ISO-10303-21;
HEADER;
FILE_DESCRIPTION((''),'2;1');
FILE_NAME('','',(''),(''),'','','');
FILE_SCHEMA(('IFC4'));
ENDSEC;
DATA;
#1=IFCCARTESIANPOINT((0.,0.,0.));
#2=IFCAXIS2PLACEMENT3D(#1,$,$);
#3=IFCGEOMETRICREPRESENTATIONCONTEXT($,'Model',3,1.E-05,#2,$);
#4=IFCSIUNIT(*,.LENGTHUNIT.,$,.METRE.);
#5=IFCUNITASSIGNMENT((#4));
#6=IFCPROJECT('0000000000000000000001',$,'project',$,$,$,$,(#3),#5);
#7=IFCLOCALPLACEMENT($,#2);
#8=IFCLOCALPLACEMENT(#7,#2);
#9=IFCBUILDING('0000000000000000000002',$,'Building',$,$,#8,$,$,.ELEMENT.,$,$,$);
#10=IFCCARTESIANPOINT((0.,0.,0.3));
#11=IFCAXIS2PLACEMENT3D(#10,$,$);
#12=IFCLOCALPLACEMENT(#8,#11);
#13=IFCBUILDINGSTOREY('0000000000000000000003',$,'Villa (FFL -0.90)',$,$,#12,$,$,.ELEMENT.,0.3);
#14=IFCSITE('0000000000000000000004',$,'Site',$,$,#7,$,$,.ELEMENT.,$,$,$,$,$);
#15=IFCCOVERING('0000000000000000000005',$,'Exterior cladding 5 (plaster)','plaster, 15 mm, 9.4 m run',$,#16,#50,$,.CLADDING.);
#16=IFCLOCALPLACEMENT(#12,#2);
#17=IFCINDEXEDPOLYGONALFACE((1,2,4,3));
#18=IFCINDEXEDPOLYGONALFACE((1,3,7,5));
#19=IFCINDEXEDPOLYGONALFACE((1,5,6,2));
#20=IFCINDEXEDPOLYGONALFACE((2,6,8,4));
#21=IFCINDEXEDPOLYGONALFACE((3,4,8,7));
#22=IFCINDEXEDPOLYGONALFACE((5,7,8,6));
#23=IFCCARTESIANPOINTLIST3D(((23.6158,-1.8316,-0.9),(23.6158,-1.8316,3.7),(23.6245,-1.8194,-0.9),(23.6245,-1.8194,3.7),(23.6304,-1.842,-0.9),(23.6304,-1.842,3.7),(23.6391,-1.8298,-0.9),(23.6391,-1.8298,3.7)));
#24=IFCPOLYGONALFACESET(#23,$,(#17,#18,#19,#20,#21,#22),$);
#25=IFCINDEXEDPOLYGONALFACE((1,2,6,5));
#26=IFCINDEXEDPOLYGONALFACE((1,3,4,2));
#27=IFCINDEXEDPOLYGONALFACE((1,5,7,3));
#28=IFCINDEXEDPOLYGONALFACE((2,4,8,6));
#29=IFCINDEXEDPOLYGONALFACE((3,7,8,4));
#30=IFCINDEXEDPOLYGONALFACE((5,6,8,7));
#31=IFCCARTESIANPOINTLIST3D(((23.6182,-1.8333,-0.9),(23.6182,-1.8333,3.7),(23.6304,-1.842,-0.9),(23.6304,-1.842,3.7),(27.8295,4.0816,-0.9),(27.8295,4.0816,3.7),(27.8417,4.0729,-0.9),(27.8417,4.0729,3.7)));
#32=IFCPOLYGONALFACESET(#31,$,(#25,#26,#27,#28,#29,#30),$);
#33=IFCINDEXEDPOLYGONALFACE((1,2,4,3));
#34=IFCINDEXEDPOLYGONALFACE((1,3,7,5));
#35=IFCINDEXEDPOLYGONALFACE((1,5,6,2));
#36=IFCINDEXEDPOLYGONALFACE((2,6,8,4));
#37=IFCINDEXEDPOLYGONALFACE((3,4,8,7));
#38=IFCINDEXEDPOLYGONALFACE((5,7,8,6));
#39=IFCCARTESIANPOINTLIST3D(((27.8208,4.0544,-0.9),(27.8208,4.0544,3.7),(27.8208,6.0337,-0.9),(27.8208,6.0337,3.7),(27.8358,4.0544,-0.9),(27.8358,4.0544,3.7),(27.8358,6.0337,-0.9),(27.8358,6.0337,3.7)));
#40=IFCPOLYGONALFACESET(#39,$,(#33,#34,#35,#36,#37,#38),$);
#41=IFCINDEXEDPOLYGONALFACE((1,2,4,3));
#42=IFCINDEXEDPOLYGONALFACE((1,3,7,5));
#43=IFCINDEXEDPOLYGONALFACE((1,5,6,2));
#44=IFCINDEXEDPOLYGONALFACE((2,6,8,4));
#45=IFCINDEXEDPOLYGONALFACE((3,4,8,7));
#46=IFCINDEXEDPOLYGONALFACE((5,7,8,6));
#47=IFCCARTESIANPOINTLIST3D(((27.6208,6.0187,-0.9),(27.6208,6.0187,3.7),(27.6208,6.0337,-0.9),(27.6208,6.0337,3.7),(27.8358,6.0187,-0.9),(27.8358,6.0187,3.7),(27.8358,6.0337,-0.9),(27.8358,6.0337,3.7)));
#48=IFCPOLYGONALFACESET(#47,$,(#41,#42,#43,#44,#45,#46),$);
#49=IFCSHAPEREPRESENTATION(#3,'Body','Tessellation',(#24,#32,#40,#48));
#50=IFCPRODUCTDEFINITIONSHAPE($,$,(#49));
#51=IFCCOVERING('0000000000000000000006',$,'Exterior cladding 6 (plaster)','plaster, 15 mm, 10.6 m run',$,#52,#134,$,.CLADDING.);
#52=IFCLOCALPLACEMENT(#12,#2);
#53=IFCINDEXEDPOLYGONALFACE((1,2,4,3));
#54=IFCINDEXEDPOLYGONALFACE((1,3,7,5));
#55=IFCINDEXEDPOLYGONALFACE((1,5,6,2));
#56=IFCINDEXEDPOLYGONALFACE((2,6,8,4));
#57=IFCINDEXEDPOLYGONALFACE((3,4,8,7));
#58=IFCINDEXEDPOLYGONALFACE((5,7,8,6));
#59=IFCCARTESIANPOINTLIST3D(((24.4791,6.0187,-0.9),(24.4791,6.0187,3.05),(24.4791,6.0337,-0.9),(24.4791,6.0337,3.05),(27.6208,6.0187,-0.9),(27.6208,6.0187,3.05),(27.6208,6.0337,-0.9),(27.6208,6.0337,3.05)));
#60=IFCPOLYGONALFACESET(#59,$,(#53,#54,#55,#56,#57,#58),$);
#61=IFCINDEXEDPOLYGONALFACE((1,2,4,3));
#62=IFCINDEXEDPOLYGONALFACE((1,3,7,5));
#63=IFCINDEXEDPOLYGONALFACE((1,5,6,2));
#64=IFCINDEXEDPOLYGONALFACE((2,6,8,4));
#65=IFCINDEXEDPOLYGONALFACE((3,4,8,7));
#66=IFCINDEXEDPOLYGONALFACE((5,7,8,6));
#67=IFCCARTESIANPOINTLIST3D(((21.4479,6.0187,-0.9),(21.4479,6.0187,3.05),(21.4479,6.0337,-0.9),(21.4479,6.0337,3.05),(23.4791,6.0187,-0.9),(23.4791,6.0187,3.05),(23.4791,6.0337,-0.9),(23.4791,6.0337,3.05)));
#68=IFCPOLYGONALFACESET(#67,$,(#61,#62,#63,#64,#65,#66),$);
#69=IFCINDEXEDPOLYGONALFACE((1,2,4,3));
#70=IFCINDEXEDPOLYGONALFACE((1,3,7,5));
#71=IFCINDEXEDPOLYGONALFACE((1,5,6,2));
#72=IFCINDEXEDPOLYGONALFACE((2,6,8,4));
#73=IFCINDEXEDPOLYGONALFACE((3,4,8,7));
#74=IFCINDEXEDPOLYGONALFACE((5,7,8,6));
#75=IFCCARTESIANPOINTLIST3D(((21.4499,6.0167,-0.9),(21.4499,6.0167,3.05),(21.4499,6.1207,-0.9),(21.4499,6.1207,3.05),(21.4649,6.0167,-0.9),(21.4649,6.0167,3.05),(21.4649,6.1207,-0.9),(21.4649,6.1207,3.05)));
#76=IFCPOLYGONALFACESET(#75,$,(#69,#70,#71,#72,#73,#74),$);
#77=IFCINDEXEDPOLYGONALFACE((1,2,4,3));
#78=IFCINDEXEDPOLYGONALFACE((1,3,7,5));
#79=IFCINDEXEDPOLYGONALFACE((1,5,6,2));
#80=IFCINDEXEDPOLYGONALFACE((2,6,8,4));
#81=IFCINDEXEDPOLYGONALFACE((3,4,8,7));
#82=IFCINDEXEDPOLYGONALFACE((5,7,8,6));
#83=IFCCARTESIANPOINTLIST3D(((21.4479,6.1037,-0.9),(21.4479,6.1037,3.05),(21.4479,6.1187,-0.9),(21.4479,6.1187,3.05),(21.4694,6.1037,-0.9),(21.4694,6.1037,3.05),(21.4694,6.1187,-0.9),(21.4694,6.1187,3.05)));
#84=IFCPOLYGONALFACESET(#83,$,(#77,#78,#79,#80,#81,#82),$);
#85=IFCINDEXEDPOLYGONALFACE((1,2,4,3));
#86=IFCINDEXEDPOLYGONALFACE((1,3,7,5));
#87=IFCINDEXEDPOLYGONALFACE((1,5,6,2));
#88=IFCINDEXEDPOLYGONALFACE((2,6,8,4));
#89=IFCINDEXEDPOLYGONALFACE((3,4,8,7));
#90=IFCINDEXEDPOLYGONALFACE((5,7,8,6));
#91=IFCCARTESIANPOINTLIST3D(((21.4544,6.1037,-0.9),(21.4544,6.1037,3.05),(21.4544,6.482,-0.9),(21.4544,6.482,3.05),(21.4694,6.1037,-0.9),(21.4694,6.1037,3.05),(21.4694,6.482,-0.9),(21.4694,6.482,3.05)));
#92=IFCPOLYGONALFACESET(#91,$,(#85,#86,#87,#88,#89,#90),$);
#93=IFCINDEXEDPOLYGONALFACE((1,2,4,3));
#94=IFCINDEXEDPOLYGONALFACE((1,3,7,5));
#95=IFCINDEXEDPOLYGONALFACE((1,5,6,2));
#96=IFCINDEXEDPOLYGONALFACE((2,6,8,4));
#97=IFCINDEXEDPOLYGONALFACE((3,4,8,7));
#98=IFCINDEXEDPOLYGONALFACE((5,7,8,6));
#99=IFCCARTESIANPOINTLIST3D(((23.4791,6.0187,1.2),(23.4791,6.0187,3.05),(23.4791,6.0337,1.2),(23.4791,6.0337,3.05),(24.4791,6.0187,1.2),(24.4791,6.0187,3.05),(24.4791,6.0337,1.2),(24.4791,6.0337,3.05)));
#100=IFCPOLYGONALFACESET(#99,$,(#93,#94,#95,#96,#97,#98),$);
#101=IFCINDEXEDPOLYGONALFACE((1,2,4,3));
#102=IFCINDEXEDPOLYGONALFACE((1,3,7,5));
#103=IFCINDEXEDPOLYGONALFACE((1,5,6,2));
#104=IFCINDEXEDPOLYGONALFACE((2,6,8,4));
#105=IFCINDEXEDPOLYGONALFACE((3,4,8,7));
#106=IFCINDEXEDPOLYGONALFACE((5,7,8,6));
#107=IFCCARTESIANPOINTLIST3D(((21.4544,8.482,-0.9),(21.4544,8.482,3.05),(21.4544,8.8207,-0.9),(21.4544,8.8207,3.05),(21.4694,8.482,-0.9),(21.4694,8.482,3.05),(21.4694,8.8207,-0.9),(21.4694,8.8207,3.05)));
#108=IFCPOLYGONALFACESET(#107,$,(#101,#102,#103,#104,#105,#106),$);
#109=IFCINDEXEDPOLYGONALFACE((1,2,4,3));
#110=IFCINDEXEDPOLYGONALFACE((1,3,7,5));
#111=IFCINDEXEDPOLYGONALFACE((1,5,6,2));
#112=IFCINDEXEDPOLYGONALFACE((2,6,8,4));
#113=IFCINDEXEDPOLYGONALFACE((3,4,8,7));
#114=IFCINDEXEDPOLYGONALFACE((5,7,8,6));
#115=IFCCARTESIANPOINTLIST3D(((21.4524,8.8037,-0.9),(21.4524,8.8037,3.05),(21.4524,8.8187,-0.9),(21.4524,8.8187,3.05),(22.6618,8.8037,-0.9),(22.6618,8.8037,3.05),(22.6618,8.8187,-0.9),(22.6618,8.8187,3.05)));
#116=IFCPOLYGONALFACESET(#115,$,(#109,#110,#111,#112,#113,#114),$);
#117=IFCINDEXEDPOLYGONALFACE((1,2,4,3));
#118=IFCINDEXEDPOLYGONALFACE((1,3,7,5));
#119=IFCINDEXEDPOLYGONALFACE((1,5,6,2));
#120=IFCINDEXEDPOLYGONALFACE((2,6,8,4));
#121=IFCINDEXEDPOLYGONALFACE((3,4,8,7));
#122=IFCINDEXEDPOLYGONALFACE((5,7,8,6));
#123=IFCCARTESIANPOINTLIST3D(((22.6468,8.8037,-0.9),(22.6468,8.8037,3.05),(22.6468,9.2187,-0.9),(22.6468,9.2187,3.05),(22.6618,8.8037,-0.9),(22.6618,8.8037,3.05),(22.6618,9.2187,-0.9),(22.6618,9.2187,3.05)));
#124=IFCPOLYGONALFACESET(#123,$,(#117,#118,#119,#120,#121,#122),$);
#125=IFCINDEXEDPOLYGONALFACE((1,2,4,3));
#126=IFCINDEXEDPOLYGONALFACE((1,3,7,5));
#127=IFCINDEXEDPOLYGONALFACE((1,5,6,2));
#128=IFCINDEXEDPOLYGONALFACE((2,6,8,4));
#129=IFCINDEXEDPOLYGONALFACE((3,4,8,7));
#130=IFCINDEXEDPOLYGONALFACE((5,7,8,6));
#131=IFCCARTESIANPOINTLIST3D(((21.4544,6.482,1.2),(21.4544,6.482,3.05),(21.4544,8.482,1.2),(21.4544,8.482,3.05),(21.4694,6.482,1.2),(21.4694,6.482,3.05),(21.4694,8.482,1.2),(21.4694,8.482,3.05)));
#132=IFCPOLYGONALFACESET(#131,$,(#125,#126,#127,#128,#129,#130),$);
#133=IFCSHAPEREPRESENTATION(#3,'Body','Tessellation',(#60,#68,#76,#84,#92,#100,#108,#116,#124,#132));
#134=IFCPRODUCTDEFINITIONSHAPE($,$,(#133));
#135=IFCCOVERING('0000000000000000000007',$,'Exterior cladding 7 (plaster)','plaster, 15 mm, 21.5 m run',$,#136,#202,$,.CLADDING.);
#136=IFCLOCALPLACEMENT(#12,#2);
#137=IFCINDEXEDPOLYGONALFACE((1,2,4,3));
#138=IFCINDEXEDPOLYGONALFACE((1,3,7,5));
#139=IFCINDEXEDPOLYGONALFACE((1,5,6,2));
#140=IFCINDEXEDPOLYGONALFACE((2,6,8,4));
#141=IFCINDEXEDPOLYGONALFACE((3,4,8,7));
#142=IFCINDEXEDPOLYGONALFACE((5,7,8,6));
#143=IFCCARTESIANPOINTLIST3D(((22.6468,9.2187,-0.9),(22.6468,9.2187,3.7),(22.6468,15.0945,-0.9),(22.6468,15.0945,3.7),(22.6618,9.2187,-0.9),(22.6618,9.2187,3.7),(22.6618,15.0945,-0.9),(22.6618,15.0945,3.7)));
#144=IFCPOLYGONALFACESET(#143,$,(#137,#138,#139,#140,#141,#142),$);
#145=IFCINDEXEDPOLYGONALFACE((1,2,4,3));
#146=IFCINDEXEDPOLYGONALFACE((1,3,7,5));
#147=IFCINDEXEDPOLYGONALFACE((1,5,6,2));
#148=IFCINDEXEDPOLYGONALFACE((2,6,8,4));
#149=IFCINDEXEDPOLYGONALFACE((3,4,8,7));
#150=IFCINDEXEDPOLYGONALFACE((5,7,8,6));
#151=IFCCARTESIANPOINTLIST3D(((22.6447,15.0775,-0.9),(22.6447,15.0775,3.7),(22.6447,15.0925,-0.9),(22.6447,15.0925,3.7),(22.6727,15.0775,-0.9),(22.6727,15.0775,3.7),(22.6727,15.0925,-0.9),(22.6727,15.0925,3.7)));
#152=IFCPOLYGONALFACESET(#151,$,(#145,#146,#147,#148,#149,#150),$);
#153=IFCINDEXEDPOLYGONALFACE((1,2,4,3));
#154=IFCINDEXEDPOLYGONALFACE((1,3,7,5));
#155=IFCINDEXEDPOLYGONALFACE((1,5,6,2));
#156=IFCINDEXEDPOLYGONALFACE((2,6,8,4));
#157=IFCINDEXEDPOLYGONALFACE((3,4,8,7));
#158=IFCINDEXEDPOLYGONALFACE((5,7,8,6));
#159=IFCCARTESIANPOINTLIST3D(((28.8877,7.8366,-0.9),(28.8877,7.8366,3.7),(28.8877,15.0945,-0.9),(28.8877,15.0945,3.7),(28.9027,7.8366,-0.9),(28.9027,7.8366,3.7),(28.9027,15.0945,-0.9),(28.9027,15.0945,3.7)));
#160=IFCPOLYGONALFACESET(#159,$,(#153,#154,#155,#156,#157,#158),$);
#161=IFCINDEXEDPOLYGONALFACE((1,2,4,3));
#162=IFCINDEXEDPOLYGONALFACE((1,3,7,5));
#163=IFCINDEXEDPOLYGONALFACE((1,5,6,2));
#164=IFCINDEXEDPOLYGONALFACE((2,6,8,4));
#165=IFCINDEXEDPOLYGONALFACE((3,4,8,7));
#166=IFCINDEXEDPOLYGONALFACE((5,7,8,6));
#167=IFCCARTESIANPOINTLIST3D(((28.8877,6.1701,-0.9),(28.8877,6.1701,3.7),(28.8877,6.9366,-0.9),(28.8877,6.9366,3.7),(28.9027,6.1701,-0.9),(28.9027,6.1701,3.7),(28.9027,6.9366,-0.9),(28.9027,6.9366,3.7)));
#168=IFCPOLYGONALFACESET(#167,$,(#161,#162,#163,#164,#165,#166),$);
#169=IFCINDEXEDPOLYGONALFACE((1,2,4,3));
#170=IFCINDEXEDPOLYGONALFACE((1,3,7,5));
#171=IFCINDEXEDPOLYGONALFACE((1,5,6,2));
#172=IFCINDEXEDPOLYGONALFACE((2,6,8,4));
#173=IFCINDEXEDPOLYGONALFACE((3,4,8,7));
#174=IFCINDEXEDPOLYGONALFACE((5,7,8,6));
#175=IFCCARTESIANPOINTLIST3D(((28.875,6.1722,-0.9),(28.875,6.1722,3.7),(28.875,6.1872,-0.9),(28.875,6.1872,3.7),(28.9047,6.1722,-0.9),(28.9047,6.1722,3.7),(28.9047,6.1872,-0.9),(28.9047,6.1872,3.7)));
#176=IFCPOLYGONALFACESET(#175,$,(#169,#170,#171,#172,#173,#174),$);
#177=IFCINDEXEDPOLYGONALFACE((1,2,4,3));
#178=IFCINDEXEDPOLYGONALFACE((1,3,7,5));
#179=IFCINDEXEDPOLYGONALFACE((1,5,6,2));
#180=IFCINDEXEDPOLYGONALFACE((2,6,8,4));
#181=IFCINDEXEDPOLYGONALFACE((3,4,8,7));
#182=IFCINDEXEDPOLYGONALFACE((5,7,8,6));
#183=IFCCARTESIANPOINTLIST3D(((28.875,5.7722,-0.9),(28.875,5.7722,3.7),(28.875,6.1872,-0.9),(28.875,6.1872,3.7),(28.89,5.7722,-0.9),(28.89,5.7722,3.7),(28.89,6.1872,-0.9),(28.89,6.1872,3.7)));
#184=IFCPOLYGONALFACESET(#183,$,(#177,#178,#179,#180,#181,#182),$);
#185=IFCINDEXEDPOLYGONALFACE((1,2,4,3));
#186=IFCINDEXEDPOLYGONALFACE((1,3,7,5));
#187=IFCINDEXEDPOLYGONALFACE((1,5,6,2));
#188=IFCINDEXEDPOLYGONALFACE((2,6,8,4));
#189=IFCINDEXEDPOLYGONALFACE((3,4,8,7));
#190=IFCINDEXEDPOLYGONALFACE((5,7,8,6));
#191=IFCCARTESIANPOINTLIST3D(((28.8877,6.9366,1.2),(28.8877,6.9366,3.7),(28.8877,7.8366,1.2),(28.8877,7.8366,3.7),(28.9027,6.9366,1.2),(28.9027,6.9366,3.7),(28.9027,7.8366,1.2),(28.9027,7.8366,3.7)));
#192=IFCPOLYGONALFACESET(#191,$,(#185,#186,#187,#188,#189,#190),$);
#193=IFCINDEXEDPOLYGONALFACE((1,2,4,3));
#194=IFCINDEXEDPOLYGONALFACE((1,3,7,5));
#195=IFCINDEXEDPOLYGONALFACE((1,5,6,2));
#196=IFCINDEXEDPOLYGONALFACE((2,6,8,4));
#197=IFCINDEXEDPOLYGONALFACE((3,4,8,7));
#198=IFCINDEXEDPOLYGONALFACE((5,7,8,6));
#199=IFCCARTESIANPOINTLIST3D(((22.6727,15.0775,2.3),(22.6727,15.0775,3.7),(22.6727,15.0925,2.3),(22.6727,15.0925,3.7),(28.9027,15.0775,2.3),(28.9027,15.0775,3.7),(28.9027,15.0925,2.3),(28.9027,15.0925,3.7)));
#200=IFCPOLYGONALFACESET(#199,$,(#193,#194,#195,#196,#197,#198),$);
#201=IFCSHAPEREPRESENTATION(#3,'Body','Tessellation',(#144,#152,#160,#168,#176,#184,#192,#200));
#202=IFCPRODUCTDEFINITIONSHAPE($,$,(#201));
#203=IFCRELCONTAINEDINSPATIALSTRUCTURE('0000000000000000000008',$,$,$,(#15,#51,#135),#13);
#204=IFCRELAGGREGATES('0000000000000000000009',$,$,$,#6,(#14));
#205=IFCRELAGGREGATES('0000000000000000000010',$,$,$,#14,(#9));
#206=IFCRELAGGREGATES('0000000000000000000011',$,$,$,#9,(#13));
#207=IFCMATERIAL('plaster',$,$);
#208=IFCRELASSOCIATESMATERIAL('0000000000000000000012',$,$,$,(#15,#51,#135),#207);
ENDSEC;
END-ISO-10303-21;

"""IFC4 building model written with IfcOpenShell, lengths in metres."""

from ifc_helpers import new_model, si_unit, frame, origin, origin_with_axes, place, context, project, spatial, polyline, outline, extrude, material, element, save


model = new_model("IFC4")

# Units and contexts
model_context = context("Model", 3, precision=1e-05, world=origin())
ifc_project = project(units=[si_unit("LENGTHUNIT", "METRE")], contexts=[model_context])

# Site, building, storey
site_placement = place(None, origin())
site = spatial("IfcSite", under=ifc_project, at=site_placement, Name="Site", CompositionType="ELEMENT")
building_placement = place(site_placement, origin())
building = spatial("IfcBuilding", under=site, at=building_placement, Name="Building", CompositionType="ELEMENT")
storey_placement = place(building_placement, frame((0.0, 0.0, 0.3)))
storey = spatial("IfcBuildingStorey", under=building, at=storey_placement, Name="Villa (FFL -0.90)", CompositionType="ELEMENT", Elevation=0.3)

# Coverings
ifc_material_1 = material(Name="plaster")
covering_1_placement = place(storey_placement, origin_with_axes())
element("IfcCovering", 1, at=covering_1_placement, inside=storey, material=ifc_material_1, Name="Exterior cladding 5 (plaster)", Description="plaster, 15 mm, 9.4 m run", PredefinedType="CLADDING", context=model_context, shape_type="SweptSolid", body=[
    extrude(outline(polyline([(23.6158, -1.8316), (23.6304, -1.842), (23.6391, -1.8298), (23.6245, -1.8194), (23.6158, -1.8316)])), frame((0.0, 0.0, -0.9)), (0.0, 0.0, 1.0), 4.6),
    extrude(outline(polyline([(23.6304, -1.842), (27.8417, 4.0729), (27.8295, 4.0816), (23.6182, -1.8333), (23.6304, -1.842)])), frame((0.0, 0.0, -0.9)), (0.0, 0.0, 1.0), 4.6),
    extrude(outline(polyline([(27.8358, 4.0544), (27.8358, 6.0337), (27.8208, 6.0337), (27.8208, 4.0544), (27.8358, 4.0544)])), frame((0.0, 0.0, -0.9)), (0.0, 0.0, 1.0), 4.6),
    extrude(outline(polyline([(27.8358, 6.0337), (27.6208, 6.0337), (27.6208, 6.0187), (27.8358, 6.0187), (27.8358, 6.0337)])), frame((0.0, 0.0, -0.9)), (0.0, 0.0, 1.0), 4.6),
])
covering_2_placement = place(storey_placement, origin_with_axes())
element("IfcCovering", 2, at=covering_2_placement, inside=storey, material=ifc_material_1, Name="Exterior cladding 6 (plaster)", Description="plaster, 15 mm, 10.6 m run", PredefinedType="CLADDING", context=model_context, shape_type="SweptSolid", body=[
    extrude(outline(polyline([(27.6208, 6.0337), (24.4791, 6.0337), (24.4791, 6.0187), (27.6208, 6.0187), (27.6208, 6.0337)])), frame((0.0, 0.0, -0.9)), (0.0, 0.0, 1.0), 3.95),
    extrude(outline(polyline([(23.4791, 6.0337), (21.4479, 6.0337), (21.4479, 6.0187), (23.4791, 6.0187), (23.4791, 6.0337)])), frame((0.0, 0.0, -0.9)), (0.0, 0.0, 1.0), 3.95),
    extrude(outline(polyline([(21.4649, 6.0167), (21.4649, 6.1207), (21.4499, 6.1207), (21.4499, 6.0167), (21.4649, 6.0167)])), frame((0.0, 0.0, -0.9)), (0.0, 0.0, 1.0), 3.95),
    extrude(outline(polyline([(21.4479, 6.1037), (21.4694, 6.1037), (21.4694, 6.1187), (21.4479, 6.1187), (21.4479, 6.1037)])), frame((0.0, 0.0, -0.9)), (0.0, 0.0, 1.0), 3.95),
    extrude(outline(polyline([(21.4694, 6.1037), (21.4694, 6.482), (21.4544, 6.482), (21.4544, 6.1037), (21.4694, 6.1037)])), frame((0.0, 0.0, -0.9)), (0.0, 0.0, 1.0), 3.95),
    extrude(outline(polyline([(24.4791, 6.0337), (23.4791, 6.0337), (23.4791, 6.0187), (24.4791, 6.0187), (24.4791, 6.0337)])), frame((0.0, 0.0, 1.2)), (0.0, 0.0, 1.0), 1.85),
    extrude(outline(polyline([(21.4694, 8.482), (21.4694, 8.8207), (21.4544, 8.8207), (21.4544, 8.482), (21.4694, 8.482)])), frame((0.0, 0.0, -0.9)), (0.0, 0.0, 1.0), 3.95),
    extrude(outline(polyline([(21.4524, 8.8037), (22.6618, 8.8037), (22.6618, 8.8187), (21.4524, 8.8187), (21.4524, 8.8037)])), frame((0.0, 0.0, -0.9)), (0.0, 0.0, 1.0), 3.95),
    extrude(outline(polyline([(22.6618, 8.8037), (22.6618, 9.2187), (22.6468, 9.2187), (22.6468, 8.8037), (22.6618, 8.8037)])), frame((0.0, 0.0, -0.9)), (0.0, 0.0, 1.0), 3.95),
    extrude(outline(polyline([(21.4694, 6.482), (21.4694, 8.482), (21.4544, 8.482), (21.4544, 6.482), (21.4694, 6.482)])), frame((0.0, 0.0, 1.2)), (0.0, 0.0, 1.0), 1.85),
])
covering_3_placement = place(storey_placement, origin_with_axes())
element("IfcCovering", 3, at=covering_3_placement, inside=storey, material=ifc_material_1, Name="Exterior cladding 7 (plaster)", Description="plaster, 15 mm, 21.5 m run", PredefinedType="CLADDING", context=model_context, shape_type="SweptSolid", body=[
    extrude(outline(polyline([(22.6618, 9.2187), (22.6618, 15.0945), (22.6468, 15.0945), (22.6468, 9.2187), (22.6618, 9.2187)])), frame((0.0, 0.0, -0.9)), (0.0, 0.0, 1.0), 4.6),
    extrude(outline(polyline([(22.6447, 15.0775), (22.6727, 15.0775), (22.6727, 15.0925), (22.6447, 15.0925), (22.6447, 15.0775)])), frame((0.0, 0.0, -0.9)), (0.0, 0.0, 1.0), 4.6),
    extrude(outline(polyline([(28.8877, 15.0945), (28.8877, 7.8366), (28.9027, 7.8366), (28.9027, 15.0945), (28.8877, 15.0945)])), frame((0.0, 0.0, -0.9)), (0.0, 0.0, 1.0), 4.6),
    extrude(outline(polyline([(28.8877, 6.9366), (28.8877, 6.1701), (28.9027, 6.1701), (28.9027, 6.9366), (28.8877, 6.9366)])), frame((0.0, 0.0, -0.9)), (0.0, 0.0, 1.0), 4.6),
    extrude(outline(polyline([(28.9047, 6.1871), (28.875, 6.1871), (28.875, 6.1722), (28.9047, 6.1722), (28.9047, 6.1871)])), frame((0.0, 0.0, -0.9)), (0.0, 0.0, 1.0), 4.6),
    extrude(outline(polyline([(28.875, 6.1871), (28.875, 5.7721), (28.89, 5.7721), (28.89, 6.1871), (28.875, 6.1871)])), frame((0.0, 0.0, -0.9)), (0.0, 0.0, 1.0), 4.6),
    extrude(outline(polyline([(28.8877, 7.8366), (28.8877, 6.9366), (28.9027, 6.9366), (28.9027, 7.8366), (28.8877, 7.8366)])), frame((0.0, 0.0, 1.2)), (0.0, 0.0, 1.0), 2.5),
    extrude(outline(polyline([(22.6727, 15.0775), (28.9027, 15.0775), (28.9027, 15.0925), (22.6727, 15.0925), (22.6727, 15.0775)])), frame((0.0, 0.0, 2.3)), (0.0, 0.0, 1.0), 1.4),
])

save(model, "model.ifc")
